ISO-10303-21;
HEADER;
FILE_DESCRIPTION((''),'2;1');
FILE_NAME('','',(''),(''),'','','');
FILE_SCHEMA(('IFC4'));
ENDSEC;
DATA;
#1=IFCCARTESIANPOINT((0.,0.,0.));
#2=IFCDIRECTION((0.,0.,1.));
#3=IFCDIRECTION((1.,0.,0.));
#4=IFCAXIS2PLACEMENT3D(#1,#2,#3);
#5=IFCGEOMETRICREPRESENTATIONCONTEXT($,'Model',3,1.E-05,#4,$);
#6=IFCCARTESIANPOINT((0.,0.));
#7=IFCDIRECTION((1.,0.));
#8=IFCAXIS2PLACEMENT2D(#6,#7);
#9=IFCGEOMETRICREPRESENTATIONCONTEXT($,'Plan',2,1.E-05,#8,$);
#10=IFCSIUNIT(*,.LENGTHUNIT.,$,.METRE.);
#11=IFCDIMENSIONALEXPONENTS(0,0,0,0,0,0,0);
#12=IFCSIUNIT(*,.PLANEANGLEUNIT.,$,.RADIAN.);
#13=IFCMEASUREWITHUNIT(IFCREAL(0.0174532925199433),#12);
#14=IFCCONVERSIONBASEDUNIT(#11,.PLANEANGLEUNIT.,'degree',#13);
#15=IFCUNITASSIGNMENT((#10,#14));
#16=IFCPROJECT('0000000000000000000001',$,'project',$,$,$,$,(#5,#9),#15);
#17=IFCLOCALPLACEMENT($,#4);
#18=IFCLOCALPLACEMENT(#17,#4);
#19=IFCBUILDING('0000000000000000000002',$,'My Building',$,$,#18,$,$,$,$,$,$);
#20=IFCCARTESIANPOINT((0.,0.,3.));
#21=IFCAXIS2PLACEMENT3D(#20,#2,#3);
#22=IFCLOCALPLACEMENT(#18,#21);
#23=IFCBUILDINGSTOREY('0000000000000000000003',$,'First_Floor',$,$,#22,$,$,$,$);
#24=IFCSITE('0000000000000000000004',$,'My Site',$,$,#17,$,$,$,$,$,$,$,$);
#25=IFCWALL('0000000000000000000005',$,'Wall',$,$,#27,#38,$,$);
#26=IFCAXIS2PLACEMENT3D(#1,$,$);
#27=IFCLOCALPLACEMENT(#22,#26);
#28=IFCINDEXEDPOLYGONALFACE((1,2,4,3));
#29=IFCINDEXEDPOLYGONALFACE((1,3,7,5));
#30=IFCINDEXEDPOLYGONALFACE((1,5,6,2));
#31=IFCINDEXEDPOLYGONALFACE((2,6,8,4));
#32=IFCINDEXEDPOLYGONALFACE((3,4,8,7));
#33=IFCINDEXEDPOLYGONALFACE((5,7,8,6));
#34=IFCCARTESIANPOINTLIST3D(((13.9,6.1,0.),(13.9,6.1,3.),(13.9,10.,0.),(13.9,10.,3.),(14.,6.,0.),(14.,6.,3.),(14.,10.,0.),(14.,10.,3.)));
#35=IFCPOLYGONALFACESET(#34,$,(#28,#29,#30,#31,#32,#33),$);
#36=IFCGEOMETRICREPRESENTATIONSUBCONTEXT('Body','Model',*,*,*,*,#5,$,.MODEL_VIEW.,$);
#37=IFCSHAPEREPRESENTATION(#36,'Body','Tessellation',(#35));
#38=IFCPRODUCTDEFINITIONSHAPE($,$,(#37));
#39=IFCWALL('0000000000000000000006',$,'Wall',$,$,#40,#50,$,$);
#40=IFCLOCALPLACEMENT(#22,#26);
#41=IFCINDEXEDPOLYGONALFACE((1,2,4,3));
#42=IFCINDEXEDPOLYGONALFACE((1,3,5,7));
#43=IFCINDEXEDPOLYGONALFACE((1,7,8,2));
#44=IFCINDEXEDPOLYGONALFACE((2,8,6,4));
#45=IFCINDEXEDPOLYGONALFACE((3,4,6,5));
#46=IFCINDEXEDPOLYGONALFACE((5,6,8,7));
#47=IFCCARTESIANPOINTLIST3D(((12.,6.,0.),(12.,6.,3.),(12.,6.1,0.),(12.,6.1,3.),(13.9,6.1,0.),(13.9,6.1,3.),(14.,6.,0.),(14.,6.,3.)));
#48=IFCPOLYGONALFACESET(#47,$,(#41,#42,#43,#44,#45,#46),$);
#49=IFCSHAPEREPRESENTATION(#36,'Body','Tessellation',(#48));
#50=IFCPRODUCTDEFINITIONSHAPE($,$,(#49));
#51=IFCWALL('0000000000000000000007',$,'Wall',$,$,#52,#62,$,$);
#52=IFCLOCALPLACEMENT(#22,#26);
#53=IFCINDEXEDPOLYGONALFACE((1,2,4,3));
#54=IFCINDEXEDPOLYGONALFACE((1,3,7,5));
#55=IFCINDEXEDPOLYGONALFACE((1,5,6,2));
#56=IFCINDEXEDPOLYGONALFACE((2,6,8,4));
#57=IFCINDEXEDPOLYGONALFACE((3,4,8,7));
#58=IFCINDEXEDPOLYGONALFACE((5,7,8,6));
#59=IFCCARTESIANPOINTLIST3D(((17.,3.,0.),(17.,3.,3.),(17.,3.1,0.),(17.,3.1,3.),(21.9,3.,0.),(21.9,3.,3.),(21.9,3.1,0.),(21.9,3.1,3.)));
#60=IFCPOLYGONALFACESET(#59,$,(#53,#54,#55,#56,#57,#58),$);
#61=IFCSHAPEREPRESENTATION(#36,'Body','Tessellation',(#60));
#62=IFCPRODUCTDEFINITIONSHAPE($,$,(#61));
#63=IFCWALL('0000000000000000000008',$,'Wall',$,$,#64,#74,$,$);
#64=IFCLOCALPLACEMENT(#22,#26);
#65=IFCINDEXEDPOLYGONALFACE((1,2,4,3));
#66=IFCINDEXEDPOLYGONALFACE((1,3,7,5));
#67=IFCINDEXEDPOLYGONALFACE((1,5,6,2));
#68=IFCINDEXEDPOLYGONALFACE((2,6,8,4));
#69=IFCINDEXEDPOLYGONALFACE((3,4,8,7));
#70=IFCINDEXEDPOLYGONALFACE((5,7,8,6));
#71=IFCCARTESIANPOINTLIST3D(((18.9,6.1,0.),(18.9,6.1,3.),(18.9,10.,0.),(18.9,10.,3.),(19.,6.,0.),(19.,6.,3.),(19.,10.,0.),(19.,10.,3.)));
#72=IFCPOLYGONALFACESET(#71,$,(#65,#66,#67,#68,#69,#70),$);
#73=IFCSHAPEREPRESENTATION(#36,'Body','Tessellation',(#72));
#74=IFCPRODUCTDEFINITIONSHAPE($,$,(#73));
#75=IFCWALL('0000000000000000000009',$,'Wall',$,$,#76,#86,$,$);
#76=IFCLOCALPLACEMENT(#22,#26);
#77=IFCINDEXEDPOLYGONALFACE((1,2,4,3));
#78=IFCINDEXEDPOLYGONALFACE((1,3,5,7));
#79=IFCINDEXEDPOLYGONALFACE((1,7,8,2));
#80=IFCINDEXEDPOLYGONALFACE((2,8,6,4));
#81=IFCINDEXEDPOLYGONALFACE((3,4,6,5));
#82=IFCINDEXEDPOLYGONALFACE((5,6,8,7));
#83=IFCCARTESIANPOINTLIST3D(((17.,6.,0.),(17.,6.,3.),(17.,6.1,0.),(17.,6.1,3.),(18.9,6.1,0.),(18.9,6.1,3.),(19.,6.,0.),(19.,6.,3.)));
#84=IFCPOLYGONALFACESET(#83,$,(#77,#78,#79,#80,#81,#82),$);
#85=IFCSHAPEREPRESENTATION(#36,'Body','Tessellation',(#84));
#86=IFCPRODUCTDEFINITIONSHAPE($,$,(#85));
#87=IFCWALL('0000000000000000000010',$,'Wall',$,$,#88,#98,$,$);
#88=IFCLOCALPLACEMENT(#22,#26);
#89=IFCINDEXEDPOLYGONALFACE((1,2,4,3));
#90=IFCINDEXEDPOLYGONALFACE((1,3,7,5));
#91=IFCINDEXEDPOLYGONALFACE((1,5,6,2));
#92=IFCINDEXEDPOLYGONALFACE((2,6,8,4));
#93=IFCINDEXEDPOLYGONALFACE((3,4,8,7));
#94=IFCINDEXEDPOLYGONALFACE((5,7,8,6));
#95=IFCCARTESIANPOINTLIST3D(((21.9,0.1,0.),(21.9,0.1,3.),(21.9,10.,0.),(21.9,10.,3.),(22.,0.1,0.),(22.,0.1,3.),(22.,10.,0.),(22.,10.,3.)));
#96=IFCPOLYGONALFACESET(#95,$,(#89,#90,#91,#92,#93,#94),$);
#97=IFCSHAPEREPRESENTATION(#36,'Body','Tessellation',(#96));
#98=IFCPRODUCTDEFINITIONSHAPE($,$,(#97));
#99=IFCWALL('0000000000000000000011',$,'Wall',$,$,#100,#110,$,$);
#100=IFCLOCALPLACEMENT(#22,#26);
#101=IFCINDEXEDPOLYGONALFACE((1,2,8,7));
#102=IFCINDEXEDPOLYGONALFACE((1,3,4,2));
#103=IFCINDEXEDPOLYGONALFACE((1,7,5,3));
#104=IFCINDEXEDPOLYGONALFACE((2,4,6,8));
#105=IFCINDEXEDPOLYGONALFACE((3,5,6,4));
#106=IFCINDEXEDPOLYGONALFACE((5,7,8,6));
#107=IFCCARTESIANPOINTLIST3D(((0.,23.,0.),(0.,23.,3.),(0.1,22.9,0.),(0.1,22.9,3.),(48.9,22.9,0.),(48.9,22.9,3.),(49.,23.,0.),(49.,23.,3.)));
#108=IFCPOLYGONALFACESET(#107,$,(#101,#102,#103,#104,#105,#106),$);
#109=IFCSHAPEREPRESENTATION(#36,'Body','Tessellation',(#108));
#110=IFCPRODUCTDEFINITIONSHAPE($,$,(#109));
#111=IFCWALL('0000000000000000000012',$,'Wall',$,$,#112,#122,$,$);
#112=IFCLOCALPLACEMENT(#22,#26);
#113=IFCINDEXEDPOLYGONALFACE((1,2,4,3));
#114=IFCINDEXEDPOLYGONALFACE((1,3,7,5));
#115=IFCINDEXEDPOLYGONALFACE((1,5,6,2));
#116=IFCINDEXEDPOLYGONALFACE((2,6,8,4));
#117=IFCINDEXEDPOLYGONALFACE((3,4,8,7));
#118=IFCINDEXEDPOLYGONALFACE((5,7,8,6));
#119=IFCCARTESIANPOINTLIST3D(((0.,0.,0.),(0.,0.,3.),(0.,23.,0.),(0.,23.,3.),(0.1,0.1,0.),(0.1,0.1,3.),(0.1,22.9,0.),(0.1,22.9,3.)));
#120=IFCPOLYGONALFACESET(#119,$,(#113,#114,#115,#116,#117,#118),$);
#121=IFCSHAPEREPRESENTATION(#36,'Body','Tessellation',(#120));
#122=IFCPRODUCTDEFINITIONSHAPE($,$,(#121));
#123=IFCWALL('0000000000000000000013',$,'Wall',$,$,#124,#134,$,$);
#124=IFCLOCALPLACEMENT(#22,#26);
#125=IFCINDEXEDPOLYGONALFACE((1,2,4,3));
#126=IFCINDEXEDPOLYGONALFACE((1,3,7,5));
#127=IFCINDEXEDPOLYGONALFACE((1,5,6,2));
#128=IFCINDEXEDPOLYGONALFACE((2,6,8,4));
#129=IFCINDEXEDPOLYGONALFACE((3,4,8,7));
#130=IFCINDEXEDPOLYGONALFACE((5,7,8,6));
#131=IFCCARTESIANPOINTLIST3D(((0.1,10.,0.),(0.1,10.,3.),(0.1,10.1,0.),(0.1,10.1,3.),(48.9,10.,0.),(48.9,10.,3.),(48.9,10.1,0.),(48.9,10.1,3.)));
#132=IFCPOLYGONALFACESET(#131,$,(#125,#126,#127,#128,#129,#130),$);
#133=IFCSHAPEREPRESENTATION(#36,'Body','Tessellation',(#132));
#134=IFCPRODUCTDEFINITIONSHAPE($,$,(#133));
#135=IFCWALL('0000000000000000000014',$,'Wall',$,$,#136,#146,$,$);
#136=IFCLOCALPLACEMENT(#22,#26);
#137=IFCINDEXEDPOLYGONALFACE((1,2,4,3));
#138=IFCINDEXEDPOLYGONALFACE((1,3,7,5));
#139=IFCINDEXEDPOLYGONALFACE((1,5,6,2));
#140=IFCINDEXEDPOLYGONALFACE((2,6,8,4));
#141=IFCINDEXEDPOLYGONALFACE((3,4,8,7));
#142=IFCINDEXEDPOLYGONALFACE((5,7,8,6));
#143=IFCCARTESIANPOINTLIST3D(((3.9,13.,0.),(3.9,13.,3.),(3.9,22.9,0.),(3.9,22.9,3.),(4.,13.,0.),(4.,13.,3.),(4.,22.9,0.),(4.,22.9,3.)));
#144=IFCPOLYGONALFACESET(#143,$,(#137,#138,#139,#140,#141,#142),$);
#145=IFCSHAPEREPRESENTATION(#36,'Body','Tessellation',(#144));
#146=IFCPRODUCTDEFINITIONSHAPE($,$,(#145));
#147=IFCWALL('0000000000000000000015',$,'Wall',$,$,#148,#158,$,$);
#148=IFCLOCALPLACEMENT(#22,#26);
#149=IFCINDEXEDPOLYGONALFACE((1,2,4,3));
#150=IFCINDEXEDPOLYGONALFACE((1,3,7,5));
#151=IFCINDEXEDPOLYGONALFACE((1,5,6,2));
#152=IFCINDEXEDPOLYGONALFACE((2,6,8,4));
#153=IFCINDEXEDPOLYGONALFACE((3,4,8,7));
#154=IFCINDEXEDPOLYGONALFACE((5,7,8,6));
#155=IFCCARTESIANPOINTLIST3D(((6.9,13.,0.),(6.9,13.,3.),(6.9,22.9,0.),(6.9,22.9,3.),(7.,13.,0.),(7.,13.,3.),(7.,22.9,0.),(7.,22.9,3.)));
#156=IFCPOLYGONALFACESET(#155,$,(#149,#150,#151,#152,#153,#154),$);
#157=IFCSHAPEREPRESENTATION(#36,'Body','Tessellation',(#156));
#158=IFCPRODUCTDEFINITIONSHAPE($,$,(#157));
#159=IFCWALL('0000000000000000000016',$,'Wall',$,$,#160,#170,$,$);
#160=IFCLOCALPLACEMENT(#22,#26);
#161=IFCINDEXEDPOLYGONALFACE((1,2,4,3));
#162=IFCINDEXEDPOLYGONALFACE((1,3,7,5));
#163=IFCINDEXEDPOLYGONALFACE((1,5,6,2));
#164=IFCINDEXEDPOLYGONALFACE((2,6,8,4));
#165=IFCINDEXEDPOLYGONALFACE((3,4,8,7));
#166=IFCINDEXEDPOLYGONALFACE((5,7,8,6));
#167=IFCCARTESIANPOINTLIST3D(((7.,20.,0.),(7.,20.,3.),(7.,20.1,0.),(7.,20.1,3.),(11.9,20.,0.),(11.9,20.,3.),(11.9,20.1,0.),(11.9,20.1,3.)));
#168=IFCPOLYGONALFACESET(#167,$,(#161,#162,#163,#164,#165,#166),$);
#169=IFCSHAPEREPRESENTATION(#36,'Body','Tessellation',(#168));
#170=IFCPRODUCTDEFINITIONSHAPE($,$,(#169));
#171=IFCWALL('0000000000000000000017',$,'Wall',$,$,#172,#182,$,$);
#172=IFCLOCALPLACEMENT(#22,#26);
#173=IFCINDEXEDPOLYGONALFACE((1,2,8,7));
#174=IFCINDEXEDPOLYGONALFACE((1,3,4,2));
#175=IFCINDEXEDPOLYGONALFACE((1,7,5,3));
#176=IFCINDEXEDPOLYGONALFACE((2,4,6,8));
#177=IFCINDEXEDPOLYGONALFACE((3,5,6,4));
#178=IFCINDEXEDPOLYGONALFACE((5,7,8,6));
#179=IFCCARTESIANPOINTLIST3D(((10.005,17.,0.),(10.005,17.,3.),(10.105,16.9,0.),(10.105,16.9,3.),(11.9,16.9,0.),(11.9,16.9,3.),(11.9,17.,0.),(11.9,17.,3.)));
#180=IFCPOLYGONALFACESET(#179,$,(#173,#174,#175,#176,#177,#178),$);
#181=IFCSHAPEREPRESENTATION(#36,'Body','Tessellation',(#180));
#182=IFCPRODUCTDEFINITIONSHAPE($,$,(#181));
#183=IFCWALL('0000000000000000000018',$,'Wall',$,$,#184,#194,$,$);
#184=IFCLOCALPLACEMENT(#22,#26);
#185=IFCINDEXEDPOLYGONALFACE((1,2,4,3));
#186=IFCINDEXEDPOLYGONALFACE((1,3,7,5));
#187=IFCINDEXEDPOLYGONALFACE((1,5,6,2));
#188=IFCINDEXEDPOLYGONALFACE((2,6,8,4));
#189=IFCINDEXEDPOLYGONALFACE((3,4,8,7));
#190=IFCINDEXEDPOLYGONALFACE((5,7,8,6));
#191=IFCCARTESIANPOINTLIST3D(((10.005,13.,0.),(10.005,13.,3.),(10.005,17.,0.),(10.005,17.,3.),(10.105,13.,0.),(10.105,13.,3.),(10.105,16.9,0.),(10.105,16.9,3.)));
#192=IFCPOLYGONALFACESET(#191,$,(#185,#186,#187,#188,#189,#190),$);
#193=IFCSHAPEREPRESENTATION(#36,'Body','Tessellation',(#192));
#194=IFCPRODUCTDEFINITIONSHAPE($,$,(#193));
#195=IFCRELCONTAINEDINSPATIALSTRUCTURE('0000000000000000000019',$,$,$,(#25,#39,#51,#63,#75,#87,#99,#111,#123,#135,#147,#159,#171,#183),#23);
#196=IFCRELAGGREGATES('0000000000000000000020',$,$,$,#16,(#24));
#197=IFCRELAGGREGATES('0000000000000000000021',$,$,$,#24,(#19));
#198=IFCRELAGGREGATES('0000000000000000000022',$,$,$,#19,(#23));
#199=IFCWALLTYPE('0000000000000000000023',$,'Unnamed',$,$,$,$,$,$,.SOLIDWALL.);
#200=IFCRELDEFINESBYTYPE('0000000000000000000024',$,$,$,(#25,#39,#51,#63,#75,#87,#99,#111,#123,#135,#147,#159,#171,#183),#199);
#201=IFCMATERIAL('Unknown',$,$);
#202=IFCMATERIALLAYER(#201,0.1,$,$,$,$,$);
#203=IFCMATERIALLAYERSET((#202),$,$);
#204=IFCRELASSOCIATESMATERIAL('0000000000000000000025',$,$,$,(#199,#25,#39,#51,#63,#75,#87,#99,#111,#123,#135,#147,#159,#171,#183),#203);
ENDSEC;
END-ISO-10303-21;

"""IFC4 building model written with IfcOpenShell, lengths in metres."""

from ifc_helpers import new_model, entity, si_unit, converted_unit, frame, origin_with_axes, origin_2d_with_axis, place, context, subcontext, project, spatial, line, indexed_curve, outline, extrude, material, layer, layer_set, layer_usage, type_object, element, save


model = new_model("IFC4")

# Units and contexts
model_context = context("Model", 3, precision=1e-05, world=origin_with_axes())
plan_context = context("Plan", 2, precision=1e-05, world=origin_2d_with_axis())
body_context = subcontext(model_context, "Body", "Model", "MODEL_VIEW")
ifc_project = project(units=[si_unit("LENGTHUNIT", "METRE"), converted_unit("PLANEANGLEUNIT", "degree", entity("IfcReal", 0.0174532925199433), si_unit("PLANEANGLEUNIT", "RADIAN"), dimensions=[0, 0, 0, 0, 0, 0, 0])], contexts=[model_context, plan_context])

# Site, building, storey
site_placement = place(None, origin_with_axes())
site = spatial("IfcSite", under=ifc_project, at=site_placement, Name="My Site")
building_placement = place(site_placement, origin_with_axes())
building = spatial("IfcBuilding", under=site, at=building_placement, Name="My Building")
storey_placement = place(building_placement, frame((0.0, 0.0, 3.0), z_axis=(0.0, 0.0, 1.0), x_axis=(1.0, 0.0, 0.0)))
storey = spatial("IfcBuildingStorey", under=building, at=storey_placement, Name="First_Floor")

# Shared definitions
ifc_material = material(Name="Unknown")

# Walls
ifc_layer_1 = layer(ifc_material, 0.1)
ifc_layer_set_1 = layer_set([ifc_layer_1])
wall_type = type_object("IfcWallType", Name="Unnamed", PredefinedType="SOLIDWALL", material=ifc_layer_set_1)
ifc_layer_usage_1 = layer_usage(ifc_layer_set_1, "AXIS2", "POSITIVE", 0.0)
wall_1_placement = place(storey_placement, frame((14.0, 6.0, 0.0), z_axis=(0.0, 0.0, 1.0), x_axis=(0.0, 1.0, 0.0)))
element("IfcWall", 1, at=wall_1_placement, inside=storey, type_object=wall_type, material=ifc_layer_usage_1, Name="Wall", context=body_context, shape_type="SweptSolid", body=[
    extrude(outline(indexed_curve([(0.0, 0.0), (0.1, 0.1), (4.0, 0.1), (4.0, 0.0)], segments=[line(1, 2, 3, 4, 1)])), origin_with_axes(), (0.0, 0.0, 1.0), 3.0),
])
ifc_layer_usage_2 = layer_usage(ifc_layer_set_1, "AXIS2", "POSITIVE", 0.0)
wall_2_placement = place(storey_placement, frame((12.0, 6.0, 0.0), z_axis=(0.0, 0.0, 1.0), x_axis=(1.0, 0.0, 0.0)))
element("IfcWall", 2, at=wall_2_placement, inside=storey, type_object=wall_type, material=ifc_layer_usage_2, Name="Wall", context=body_context, shape_type="SweptSolid", body=[
    extrude(outline(indexed_curve([(0.0, 0.0), (0.0, 0.1), (1.9, 0.1), (2.0, 0.0)], segments=[line(1, 2, 3, 4, 1)])), origin_with_axes(), (0.0, 0.0, 1.0), 3.0),
])
ifc_layer_usage_3 = layer_usage(ifc_layer_set_1, "AXIS2", "POSITIVE", 0.0)
wall_3_placement = place(storey_placement, frame((17.0, 3.0, 0.0), z_axis=(0.0, 0.0, 1.0), x_axis=(1.0, 0.0, 0.0)))
element("IfcWall", 3, at=wall_3_placement, inside=storey, type_object=wall_type, material=ifc_layer_usage_3, Name="Wall", context=body_context, shape_type="SweptSolid", body=[
    extrude(outline(indexed_curve([(0.0, 0.0), (0.0, 0.1), (4.9, 0.1), (4.9, 0.0)], segments=[line(1, 2, 3, 4, 1)])), origin_with_axes(), (0.0, 0.0, 1.0), 3.0),
])
ifc_layer_usage_4 = layer_usage(ifc_layer_set_1, "AXIS2", "POSITIVE", 0.0)
wall_4_placement = place(storey_placement, frame((19.0, 6.0, 0.0), z_axis=(0.0, 0.0, 1.0), x_axis=(0.0, 1.0, 0.0)))
element("IfcWall", 4, at=wall_4_placement, inside=storey, type_object=wall_type, material=ifc_layer_usage_4, Name="Wall", context=body_context, shape_type="SweptSolid", body=[
    extrude(outline(indexed_curve([(0.0, 0.0), (0.1, 0.1), (4.0, 0.1), (4.0, 0.0)], segments=[line(1, 2, 3, 4, 1)])), origin_with_axes(), (0.0, 0.0, 1.0), 3.0),
])
ifc_layer_usage_5 = layer_usage(ifc_layer_set_1, "AXIS2", "POSITIVE", 0.0)
wall_5_placement = place(storey_placement, frame((17.0, 6.0, 0.0), z_axis=(0.0, 0.0, 1.0), x_axis=(1.0, 0.0, 0.0)))
element("IfcWall", 5, at=wall_5_placement, inside=storey, type_object=wall_type, material=ifc_layer_usage_5, Name="Wall", context=body_context, shape_type="SweptSolid", body=[
    extrude(outline(indexed_curve([(0.0, 0.0), (0.0, 0.1), (1.9, 0.1), (2.0, 0.0)], segments=[line(1, 2, 3, 4, 1)])), origin_with_axes(), (0.0, 0.0, 1.0), 3.0),
])
ifc_layer_usage_6 = layer_usage(ifc_layer_set_1, "AXIS2", "POSITIVE", 0.0)
wall_6_placement = place(storey_placement, frame((21.9, 10.0, 0.0), z_axis=(0.0, 0.0, 1.0), x_axis=(0.0, -1.0, 0.0)))
element("IfcWall", 6, at=wall_6_placement, inside=storey, type_object=wall_type, material=ifc_layer_usage_6, Name="Wall", context=body_context, shape_type="SweptSolid", body=[
    extrude(outline(indexed_curve([(0.0, 0.0), (0.0, 0.1), (9.9, 0.1), (9.9, 0.0)], segments=[line(1, 2, 3, 4, 1)])), origin_with_axes(), (0.0, 0.0, 1.0), 3.0),
])
ifc_layer_usage_7 = layer_usage(ifc_layer_set_1, "AXIS2", "POSITIVE", 0.0)
wall_7_placement = place(storey_placement, frame((0.1, 22.9, 0.0), z_axis=(0.0, 0.0, 1.0), x_axis=(1.0, 0.0, 0.0)))
element("IfcWall", 7, at=wall_7_placement, inside=storey, type_object=wall_type, material=ifc_layer_usage_7, Name="Wall", context=body_context, shape_type="SweptSolid", body=[
    extrude(outline(indexed_curve([(0.0, 0.0), (-0.1, 0.1), (48.9, 0.1), (48.8, 0.0)], segments=[line(1, 2, 3, 4, 1)])), origin_with_axes(), (0.0, 0.0, 1.0), 3.0),
])
ifc_layer_usage_8 = layer_usage(ifc_layer_set_1, "AXIS2", "POSITIVE", 0.0)
wall_8_placement = place(storey_placement, frame((0.1, 0.1, 0.0), z_axis=(0.0, 0.0, 1.0), x_axis=(0.0, 1.0, 0.0)))
element("IfcWall", 8, at=wall_8_placement, inside=storey, type_object=wall_type, material=ifc_layer_usage_8, Name="Wall", context=body_context, shape_type="SweptSolid", body=[
    extrude(outline(indexed_curve([(0.0, 0.0), (-0.1, 0.1), (22.9, 0.1), (22.8, 0.0)], segments=[line(1, 2, 3, 4, 1)])), origin_with_axes(), (0.0, 0.0, 1.0), 3.0),
])
ifc_layer_usage_9 = layer_usage(ifc_layer_set_1, "AXIS2", "POSITIVE", 0.0)
wall_9_placement = place(storey_placement, frame((0.1, 10.0, 0.0), z_axis=(0.0, 0.0, 1.0), x_axis=(1.0, 0.0, 0.0)))
element("IfcWall", 9, at=wall_9_placement, inside=storey, type_object=wall_type, material=ifc_layer_usage_9, Name="Wall", context=body_context, shape_type="SweptSolid", body=[
    extrude(outline(indexed_curve([(0.0, 0.0), (0.0, 0.1), (48.8, 0.1), (48.8, 0.0)], segments=[line(1, 2, 3, 4, 1)])), origin_with_axes(), (0.0, 0.0, 1.0), 3.0),
])
ifc_layer_usage_10 = layer_usage(ifc_layer_set_1, "AXIS2", "POSITIVE", 0.0)
wall_10_placement = place(storey_placement, frame((3.9, 22.9, 0.0), z_axis=(0.0, 0.0, 1.0), x_axis=(0.0, -1.0, 0.0)))
element("IfcWall", 10, at=wall_10_placement, inside=storey, type_object=wall_type, material=ifc_layer_usage_10, Name="Wall", context=body_context, shape_type="SweptSolid", body=[
    extrude(outline(indexed_curve([(0.0, 0.0), (0.0, 0.1), (9.9, 0.1), (9.9, 0.0)], segments=[line(1, 2, 3, 4, 1)])), origin_with_axes(), (0.0, 0.0, 1.0), 3.0),
])
ifc_layer_usage_11 = layer_usage(ifc_layer_set_1, "AXIS2", "POSITIVE", 0.0)
wall_11_placement = place(storey_placement, frame((6.9, 22.9, 0.0), z_axis=(0.0, 0.0, 1.0), x_axis=(0.0, -1.0, 0.0)))
element("IfcWall", 11, at=wall_11_placement, inside=storey, type_object=wall_type, material=ifc_layer_usage_11, Name="Wall", context=body_context, shape_type="SweptSolid", body=[
    extrude(outline(indexed_curve([(0.0, 0.0), (0.0, 0.1), (9.9, 0.1), (9.9, 0.0)], segments=[line(1, 2, 3, 4, 1)])), origin_with_axes(), (0.0, 0.0, 1.0), 3.0),
])
ifc_layer_usage_12 = layer_usage(ifc_layer_set_1, "AXIS2", "POSITIVE", 0.0)
wall_12_placement = place(storey_placement, frame((7.0, 20.0, 0.0), z_axis=(0.0, 0.0, 1.0), x_axis=(1.0, 0.0, 0.0)))
element("IfcWall", 12, at=wall_12_placement, inside=storey, type_object=wall_type, material=ifc_layer_usage_12, Name="Wall", context=body_context, shape_type="SweptSolid", body=[
    extrude(outline(indexed_curve([(0.0, 0.0), (0.0, 0.1), (4.9, 0.1), (4.9, 0.0)], segments=[line(1, 2, 3, 4, 1)])), origin_with_axes(), (0.0, 0.0, 1.0), 3.0),
])
ifc_layer_usage_13 = layer_usage(ifc_layer_set_1, "AXIS2", "POSITIVE", 0.0)
wall_13_placement = place(storey_placement, frame((11.9, 17.0, 0.0), z_axis=(0.0, 0.0, 1.0), x_axis=(-1.0, 0.0, 0.0)))
element("IfcWall", 13, at=wall_13_placement, inside=storey, type_object=wall_type, material=ifc_layer_usage_13, Name="Wall", context=body_context, shape_type="SweptSolid", body=[
    extrude(outline(indexed_curve([(0.0, 0.0), (0.0, 0.1), (1.795, 0.1), (1.895, 0.0)], segments=[line(1, 2, 3, 4, 1)])), origin_with_axes(), (0.0, 0.0, 1.0), 3.0),
])
ifc_layer_usage_14 = layer_usage(ifc_layer_set_1, "AXIS2", "POSITIVE", 0.0)
wall_14_placement = place(storey_placement, frame((10.005, 17.0, 0.0), z_axis=(0.0, 0.0, 1.0), x_axis=(0.0, -1.0, 0.0)))
element("IfcWall", 14, at=wall_14_placement, inside=storey, type_object=wall_type, material=ifc_layer_usage_14, Name="Wall", context=body_context, shape_type="SweptSolid", body=[
    extrude(outline(indexed_curve([(0.0, 0.0), (0.1, 0.1), (4.0, 0.1), (4.0, 0.0)], segments=[line(1, 2, 3, 4, 1)])), origin_with_axes(), (0.0, 0.0, 1.0), 3.0),
])

save(model, "model.ifc")
